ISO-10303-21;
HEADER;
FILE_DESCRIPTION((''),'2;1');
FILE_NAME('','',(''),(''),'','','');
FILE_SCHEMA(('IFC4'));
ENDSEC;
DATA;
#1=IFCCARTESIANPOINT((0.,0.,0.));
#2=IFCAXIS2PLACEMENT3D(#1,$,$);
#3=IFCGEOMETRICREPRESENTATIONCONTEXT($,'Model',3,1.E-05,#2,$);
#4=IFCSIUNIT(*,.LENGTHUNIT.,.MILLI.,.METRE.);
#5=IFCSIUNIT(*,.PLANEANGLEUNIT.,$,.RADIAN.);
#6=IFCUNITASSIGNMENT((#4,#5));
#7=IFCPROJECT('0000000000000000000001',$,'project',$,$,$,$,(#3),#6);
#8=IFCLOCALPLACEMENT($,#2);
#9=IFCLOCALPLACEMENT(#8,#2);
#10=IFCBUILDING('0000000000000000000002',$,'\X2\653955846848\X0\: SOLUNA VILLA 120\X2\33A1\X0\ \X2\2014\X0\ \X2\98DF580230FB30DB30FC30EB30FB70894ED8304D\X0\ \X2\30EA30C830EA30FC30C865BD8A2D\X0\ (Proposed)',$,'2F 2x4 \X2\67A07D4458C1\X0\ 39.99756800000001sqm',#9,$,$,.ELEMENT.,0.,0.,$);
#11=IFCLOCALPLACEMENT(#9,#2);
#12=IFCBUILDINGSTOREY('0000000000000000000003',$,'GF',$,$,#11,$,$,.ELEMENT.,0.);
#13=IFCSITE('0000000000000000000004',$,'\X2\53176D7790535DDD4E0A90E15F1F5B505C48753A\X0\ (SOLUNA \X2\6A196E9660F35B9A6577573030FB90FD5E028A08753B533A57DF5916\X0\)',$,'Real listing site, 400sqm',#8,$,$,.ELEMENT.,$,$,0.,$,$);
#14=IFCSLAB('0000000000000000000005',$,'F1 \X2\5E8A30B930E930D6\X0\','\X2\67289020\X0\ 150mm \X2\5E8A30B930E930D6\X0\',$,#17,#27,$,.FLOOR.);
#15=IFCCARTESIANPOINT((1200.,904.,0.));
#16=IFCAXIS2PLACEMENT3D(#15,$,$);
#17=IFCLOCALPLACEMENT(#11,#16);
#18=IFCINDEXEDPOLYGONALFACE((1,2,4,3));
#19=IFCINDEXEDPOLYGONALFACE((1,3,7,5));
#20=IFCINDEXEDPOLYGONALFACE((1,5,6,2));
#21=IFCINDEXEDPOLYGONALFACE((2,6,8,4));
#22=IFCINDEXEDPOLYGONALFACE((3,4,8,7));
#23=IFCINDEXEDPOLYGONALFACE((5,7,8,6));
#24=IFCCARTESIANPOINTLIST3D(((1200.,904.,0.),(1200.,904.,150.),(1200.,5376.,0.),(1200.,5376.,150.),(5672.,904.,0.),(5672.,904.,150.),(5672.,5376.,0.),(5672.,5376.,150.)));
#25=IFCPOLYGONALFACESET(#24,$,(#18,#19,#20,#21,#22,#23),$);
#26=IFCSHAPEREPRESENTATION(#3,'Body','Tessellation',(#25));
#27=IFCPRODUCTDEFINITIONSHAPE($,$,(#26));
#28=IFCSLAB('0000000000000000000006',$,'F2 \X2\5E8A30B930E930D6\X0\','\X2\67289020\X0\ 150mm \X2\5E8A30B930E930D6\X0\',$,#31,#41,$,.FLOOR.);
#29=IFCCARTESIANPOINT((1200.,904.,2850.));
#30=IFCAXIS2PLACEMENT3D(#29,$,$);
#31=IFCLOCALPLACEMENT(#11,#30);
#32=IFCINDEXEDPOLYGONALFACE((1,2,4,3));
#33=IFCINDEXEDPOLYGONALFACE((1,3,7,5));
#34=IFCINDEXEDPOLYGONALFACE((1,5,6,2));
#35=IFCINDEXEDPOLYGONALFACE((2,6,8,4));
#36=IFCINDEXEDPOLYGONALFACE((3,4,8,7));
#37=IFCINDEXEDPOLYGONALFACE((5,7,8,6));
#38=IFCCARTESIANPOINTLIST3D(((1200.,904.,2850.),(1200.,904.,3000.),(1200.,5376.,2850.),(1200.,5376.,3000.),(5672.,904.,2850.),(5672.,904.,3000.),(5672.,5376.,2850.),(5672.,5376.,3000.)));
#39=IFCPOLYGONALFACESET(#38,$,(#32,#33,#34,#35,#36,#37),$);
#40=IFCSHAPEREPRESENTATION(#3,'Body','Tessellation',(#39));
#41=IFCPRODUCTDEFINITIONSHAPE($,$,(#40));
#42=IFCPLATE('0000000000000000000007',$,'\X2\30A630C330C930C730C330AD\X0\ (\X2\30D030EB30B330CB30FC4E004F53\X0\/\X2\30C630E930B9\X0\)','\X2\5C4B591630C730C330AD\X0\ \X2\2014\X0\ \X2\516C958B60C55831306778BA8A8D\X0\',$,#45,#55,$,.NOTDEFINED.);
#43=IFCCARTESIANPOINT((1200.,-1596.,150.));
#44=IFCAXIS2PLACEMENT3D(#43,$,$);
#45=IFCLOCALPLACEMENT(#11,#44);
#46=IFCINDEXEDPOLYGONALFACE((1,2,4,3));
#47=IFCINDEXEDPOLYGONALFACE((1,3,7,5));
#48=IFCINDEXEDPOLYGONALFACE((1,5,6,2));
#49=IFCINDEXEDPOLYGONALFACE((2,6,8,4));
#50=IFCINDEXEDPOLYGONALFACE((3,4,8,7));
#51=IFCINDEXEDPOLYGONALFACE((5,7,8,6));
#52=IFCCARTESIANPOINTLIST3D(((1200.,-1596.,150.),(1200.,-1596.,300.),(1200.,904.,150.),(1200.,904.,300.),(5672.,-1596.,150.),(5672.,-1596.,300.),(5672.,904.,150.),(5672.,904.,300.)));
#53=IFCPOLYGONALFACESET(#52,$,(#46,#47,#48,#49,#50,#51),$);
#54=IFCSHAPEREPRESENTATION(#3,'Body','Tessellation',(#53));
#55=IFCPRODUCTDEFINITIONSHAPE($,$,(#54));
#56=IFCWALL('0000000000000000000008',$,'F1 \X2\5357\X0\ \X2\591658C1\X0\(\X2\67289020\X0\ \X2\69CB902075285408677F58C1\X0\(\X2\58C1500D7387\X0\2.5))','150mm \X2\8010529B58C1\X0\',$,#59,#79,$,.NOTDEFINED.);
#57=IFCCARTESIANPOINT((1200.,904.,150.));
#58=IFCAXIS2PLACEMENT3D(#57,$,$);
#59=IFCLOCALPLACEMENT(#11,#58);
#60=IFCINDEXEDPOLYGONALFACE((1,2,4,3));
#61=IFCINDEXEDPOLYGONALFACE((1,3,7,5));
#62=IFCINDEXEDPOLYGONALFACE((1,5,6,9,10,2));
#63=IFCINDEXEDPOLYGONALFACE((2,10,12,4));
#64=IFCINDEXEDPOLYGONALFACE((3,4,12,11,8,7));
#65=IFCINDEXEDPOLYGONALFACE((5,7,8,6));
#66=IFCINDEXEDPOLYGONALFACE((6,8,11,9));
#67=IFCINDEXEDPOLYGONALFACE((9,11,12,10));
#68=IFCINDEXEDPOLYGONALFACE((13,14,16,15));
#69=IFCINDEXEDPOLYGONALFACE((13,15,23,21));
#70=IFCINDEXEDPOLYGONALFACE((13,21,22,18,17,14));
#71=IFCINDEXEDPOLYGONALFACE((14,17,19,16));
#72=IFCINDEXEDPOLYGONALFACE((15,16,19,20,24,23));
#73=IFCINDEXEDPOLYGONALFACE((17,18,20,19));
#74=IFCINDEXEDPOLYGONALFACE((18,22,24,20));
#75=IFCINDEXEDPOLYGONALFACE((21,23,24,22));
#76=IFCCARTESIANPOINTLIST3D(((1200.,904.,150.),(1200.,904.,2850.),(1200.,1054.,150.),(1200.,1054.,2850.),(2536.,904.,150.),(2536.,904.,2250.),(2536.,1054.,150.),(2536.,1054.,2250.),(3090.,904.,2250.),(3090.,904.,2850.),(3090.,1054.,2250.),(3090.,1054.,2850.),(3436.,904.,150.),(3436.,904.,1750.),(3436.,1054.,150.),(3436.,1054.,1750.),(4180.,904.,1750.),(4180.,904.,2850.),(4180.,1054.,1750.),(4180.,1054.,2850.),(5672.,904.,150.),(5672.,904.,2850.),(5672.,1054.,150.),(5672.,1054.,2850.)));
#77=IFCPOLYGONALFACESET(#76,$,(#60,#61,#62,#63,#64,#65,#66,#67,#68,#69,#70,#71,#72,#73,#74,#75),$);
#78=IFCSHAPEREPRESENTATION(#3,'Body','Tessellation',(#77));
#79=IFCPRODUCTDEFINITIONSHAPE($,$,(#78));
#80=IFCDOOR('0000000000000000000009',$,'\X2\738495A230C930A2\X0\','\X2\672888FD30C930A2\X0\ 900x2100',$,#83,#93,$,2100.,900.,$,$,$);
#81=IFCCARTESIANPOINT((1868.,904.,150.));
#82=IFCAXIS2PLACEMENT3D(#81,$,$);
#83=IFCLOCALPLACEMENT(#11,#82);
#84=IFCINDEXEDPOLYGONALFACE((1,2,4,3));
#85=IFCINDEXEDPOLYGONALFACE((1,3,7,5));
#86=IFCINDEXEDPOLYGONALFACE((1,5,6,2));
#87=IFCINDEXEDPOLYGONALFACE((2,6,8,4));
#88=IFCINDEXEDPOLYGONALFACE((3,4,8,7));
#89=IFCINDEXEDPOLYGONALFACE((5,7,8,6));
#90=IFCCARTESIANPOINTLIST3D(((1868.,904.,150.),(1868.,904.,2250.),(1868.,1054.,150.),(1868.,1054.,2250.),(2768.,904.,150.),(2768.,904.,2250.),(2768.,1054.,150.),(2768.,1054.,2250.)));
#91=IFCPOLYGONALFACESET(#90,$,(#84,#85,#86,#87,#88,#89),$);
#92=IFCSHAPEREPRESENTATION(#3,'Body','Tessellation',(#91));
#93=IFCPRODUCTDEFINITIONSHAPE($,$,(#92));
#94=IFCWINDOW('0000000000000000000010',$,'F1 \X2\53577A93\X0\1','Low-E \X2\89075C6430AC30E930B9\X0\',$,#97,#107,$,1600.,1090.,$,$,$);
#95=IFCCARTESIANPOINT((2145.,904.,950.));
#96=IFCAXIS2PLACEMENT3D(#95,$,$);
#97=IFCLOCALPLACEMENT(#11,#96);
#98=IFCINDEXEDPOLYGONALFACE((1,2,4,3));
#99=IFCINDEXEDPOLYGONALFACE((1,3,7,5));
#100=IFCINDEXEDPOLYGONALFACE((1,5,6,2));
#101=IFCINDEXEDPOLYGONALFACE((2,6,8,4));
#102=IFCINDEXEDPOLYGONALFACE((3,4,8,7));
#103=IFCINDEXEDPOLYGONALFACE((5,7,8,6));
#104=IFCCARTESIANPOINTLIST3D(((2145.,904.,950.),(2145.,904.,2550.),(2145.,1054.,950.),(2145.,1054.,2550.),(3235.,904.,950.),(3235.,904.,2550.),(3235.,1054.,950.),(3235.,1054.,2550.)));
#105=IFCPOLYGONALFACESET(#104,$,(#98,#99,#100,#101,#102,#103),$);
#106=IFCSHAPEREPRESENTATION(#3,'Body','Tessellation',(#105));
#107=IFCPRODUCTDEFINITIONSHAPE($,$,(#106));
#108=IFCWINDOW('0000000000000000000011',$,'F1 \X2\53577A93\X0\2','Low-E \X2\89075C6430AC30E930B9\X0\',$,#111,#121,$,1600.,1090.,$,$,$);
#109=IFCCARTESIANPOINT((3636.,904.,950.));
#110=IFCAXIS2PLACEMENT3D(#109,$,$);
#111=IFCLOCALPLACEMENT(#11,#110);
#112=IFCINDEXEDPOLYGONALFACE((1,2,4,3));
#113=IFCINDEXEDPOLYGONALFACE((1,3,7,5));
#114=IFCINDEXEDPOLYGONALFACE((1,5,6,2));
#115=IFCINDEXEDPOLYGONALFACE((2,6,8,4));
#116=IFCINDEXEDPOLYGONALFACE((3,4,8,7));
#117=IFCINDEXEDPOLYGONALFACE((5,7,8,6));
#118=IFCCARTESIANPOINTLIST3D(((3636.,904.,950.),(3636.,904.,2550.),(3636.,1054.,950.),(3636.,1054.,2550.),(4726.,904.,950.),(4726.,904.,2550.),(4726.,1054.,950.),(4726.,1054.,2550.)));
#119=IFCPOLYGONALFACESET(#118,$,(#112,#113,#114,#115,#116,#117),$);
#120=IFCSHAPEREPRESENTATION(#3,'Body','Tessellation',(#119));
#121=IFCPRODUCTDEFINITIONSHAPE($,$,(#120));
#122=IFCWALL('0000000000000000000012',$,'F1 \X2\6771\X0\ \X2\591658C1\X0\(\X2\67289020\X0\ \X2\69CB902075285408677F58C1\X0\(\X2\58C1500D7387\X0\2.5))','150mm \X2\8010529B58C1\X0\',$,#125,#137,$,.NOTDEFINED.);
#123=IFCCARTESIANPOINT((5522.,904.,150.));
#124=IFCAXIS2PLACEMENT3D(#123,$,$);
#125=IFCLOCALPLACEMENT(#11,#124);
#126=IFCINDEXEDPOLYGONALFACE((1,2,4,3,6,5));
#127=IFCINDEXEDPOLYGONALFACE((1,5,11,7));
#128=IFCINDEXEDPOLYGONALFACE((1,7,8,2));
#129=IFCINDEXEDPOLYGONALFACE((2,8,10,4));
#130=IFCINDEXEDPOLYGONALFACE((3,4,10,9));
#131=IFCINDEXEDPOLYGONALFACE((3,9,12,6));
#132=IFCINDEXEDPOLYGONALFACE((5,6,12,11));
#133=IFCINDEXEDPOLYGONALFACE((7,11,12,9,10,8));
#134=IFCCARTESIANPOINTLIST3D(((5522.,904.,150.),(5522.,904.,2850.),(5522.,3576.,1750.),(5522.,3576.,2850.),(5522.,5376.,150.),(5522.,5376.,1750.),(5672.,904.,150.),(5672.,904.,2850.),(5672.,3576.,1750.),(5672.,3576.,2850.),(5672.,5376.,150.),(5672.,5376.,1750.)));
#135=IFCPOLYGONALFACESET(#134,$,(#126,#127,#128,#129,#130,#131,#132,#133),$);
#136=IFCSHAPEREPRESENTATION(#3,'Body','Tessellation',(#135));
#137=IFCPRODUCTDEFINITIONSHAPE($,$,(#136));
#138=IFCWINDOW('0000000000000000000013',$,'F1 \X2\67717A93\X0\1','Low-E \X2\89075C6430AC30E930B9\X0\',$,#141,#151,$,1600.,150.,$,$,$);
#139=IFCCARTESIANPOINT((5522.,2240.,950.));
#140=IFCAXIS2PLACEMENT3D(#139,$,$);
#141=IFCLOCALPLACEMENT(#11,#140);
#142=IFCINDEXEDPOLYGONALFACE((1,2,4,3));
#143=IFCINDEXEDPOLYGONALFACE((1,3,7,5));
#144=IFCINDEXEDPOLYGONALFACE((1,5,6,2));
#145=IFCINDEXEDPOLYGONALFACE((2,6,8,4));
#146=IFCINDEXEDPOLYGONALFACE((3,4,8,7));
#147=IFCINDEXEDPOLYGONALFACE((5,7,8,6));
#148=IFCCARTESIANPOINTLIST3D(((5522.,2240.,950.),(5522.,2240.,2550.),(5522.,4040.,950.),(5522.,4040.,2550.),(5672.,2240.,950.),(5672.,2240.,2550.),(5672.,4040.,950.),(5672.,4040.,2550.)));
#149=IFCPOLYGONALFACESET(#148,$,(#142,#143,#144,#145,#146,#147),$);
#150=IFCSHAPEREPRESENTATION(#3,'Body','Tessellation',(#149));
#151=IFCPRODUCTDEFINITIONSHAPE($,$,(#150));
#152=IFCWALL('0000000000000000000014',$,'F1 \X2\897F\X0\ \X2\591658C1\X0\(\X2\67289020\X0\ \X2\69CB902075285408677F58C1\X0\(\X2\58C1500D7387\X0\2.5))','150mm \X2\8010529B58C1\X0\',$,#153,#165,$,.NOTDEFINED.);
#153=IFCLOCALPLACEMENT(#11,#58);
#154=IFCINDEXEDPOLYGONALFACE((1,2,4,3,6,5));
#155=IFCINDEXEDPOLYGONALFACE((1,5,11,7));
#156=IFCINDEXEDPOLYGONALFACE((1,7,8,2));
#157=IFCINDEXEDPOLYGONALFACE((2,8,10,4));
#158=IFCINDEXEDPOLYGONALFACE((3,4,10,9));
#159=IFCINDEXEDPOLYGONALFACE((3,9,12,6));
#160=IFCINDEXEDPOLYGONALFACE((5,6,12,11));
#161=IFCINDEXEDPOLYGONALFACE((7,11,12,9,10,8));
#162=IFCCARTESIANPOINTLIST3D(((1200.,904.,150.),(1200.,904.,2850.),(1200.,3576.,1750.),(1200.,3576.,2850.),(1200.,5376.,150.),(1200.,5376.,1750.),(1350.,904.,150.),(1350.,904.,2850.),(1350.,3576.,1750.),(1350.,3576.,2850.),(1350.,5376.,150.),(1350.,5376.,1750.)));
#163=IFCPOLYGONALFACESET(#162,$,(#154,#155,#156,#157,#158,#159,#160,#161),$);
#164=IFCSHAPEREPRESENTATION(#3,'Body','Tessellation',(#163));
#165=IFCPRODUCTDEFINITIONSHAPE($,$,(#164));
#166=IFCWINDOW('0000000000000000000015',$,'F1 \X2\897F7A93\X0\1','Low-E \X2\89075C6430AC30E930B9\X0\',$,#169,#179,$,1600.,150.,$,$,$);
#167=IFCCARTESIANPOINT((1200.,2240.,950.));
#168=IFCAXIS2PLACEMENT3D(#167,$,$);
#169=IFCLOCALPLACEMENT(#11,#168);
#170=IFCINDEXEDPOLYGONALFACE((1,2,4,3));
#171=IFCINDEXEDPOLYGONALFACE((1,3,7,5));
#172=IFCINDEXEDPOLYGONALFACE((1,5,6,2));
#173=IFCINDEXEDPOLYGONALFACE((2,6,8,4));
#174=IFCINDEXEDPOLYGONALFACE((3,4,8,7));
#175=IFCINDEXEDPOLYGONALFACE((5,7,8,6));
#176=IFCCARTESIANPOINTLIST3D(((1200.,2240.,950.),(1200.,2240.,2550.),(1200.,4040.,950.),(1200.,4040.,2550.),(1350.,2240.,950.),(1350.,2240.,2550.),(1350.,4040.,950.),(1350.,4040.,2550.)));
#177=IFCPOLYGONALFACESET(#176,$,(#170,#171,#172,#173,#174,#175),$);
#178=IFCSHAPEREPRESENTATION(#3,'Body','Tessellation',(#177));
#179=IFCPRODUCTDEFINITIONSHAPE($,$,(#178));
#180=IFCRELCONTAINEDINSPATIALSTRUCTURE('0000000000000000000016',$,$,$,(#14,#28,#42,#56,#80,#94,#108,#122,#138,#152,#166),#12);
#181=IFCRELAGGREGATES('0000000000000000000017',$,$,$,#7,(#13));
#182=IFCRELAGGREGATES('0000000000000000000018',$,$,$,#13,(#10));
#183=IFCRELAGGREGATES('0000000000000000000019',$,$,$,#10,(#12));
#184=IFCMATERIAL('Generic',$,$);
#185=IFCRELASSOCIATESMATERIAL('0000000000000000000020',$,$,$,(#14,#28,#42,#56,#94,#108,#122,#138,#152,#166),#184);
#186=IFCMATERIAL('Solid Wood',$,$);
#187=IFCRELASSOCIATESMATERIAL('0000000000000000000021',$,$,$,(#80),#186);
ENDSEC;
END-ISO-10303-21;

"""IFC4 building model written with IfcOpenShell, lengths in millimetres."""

from ifc_helpers import new_model, si_unit, frame, frame_2d, origin, place, context, project, spatial, rectangle, extrude, material, element, fill, save


model = new_model("IFC4")

# Units and contexts
model_context = context("Model", 3, precision=1e-05, world=origin())
ifc_project = project(units=[si_unit("LENGTHUNIT", "METRE", prefix="MILLI"), si_unit("PLANEANGLEUNIT", "RADIAN")], contexts=[model_context])

# Site, building, storey
site_placement = place(None, origin())
site = spatial("IfcSite", under=ifc_project, at=site_placement, Name="北海道川上郡弟子屈町 (SOLUNA 標準想定敷地・都市計画区域外)", ObjectType="Real listing site, 400sqm", CompositionType="ELEMENT", RefElevation=0.0)
building_placement = place(site_placement, origin())
building = spatial("IfcBuilding", under=site, at=building_placement, Name="改善案: SOLUNA VILLA 120㎡ — 食堂・ホール・炉付き リトリート施設 (Proposed)", ObjectType="2F 2x4 枠組壁 39.99756800000001sqm", CompositionType="ELEMENT", ElevationOfRefHeight=0.0, ElevationOfTerrain=0.0)
storey_placement = place(building_placement, origin())
storey = spatial("IfcBuildingStorey", under=building, at=storey_placement, Name="GF", CompositionType="ELEMENT", Elevation=0.0)

# Slabs
ifc_material_1 = material(Name="Generic")
slab_1_placement = place(storey_placement, frame((1200.0, 904.0, 0.0)))
element("IfcSlab", 1, at=slab_1_placement, inside=storey, material=ifc_material_1, Name="F1 床スラブ", Description="木造 150mm 床スラブ", PredefinedType="FLOOR", context=model_context, shape_type="SweptSolid", body=[
    extrude(rectangle(XDim=4472.0, YDim=4472.0, at=frame_2d((2236.0, 2236.0))), frame((1200.0, 904.0, 0.0)), (0.0, 0.0, 1.0), 150.0),
])
slab_2_placement = place(storey_placement, frame((1200.0, 904.0, 2850.0)))
element("IfcSlab", 2, at=slab_2_placement, inside=storey, material=ifc_material_1, Name="F2 床スラブ", Description="木造 150mm 床スラブ", PredefinedType="FLOOR", context=model_context, shape_type="SweptSolid", body=[
    extrude(rectangle(XDim=4472.0, YDim=4472.0, at=frame_2d((2236.0, 2236.0))), frame((1200.0, 904.0, 2850.0)), (0.0, 0.0, 1.0), 150.0),
])

# Plate
plate_placement = place(storey_placement, frame((1200.0, -1596.0, 150.0)))
element("IfcPlate", 3, at=plate_placement, inside=storey, material=ifc_material_1, Name="ウッドデッキ (バルコニー一体/テラス)", Description="屋外デッキ — 公開情報で確認", PredefinedType="NOTDEFINED", context=model_context, shape_type="SweptSolid", body=[
    extrude(rectangle(XDim=4472.0, YDim=2500.0, at=frame_2d((2236.0, 1250.0))), frame((1200.0, -1596.0, 150.0)), (0.0, 0.0, 1.0), 150.0),
])

# Wall, openings, door, windows
wall_1_placement = place(storey_placement, frame((1200.0, 904.0, 150.0)))
wall_1 = element("IfcWall", 4, at=wall_1_placement, inside=storey, material=ifc_material_1, Name="F1 南 外壁(木造 構造用合板壁(壁倍率2.5))", Description="150mm 耐力壁", PredefinedType="NOTDEFINED", context=model_context, shape_type="SweptSolid", body=[
    extrude(rectangle(XDim=4472.0, YDim=150.0, at=frame_2d((2236.0, 75.0))), frame((1200.0, 904.0, 150.0)), (0.0, 0.0, 1.0), 2700.0),
])
opening_1_placement = place(storey_placement, frame((1868.0, 904.0, 150.0)))
opening_1 = element("IfcOpeningElement", 5, at=opening_1_placement, cuts=wall_1, PredefinedType="NOTDEFINED", context=model_context, shape_type="SweptSolid", body=[
    extrude(rectangle(XDim=900.0, YDim=150.0, at=frame_2d((450.0, 75.0))), frame((1868.0, 904.0, 150.0)), (0.0, 0.0, 1.0), 2100.0),
])
opening_2_placement = place(storey_placement, frame((2145.0, 904.0, 950.0)))
opening_2 = element("IfcOpeningElement", 6, at=opening_2_placement, cuts=wall_1, PredefinedType="NOTDEFINED", context=model_context, shape_type="SweptSolid", body=[
    extrude(rectangle(XDim=1090.0, YDim=150.0, at=frame_2d((545.0, 75.0))), frame((2145.0, 904.0, 950.0)), (0.0, 0.0, 1.0), 1600.0),
])
opening_3_placement = place(storey_placement, frame((3636.0, 904.0, 950.0)))
opening_3 = element("IfcOpeningElement", 7, at=opening_3_placement, cuts=wall_1, PredefinedType="NOTDEFINED", context=model_context, shape_type="SweptSolid", body=[
    extrude(rectangle(XDim=1090.0, YDim=150.0, at=frame_2d((545.0, 75.0))), frame((3636.0, 904.0, 950.0)), (0.0, 0.0, 1.0), 1600.0),
])
ifc_material_2 = material(Name="Solid Wood")
door_placement = place(storey_placement, frame((1868.0, 904.0, 150.0)))
door = element("IfcDoor", 8, at=door_placement, inside=storey, material=ifc_material_2, Name="玄関ドア", Description="木製ドア 900x2100", OverallHeight=2100.0, OverallWidth=900.0, context=model_context, shape_type="SweptSolid", body=[
    extrude(rectangle(XDim=900.0, YDim=150.0, at=frame_2d((450.0, 75.0))), frame((1868.0, 904.0, 150.0)), (0.0, 0.0, 1.0), 2100.0),
])
fill(opening_1, door)
window_1_placement = place(storey_placement, frame((2145.0, 904.0, 950.0)))
window_1 = element("IfcWindow", 9, at=window_1_placement, inside=storey, material=ifc_material_1, Name="F1 南窓1", Description="Low-E 複層ガラス", OverallHeight=1600.0, OverallWidth=1090.0, context=model_context, shape_type="SweptSolid", body=[
    extrude(rectangle(XDim=1090.0, YDim=150.0, at=frame_2d((545.0, 75.0))), frame((2145.0, 904.0, 950.0)), (0.0, 0.0, 1.0), 1600.0),
])
fill(opening_2, window_1)
window_2_placement = place(storey_placement, frame((3636.0, 904.0, 950.0)))
window_2 = element("IfcWindow", 10, at=window_2_placement, inside=storey, material=ifc_material_1, Name="F1 南窓2", Description="Low-E 複層ガラス", OverallHeight=1600.0, OverallWidth=1090.0, context=model_context, shape_type="SweptSolid", body=[
    extrude(rectangle(XDim=1090.0, YDim=150.0, at=frame_2d((545.0, 75.0))), frame((3636.0, 904.0, 950.0)), (0.0, 0.0, 1.0), 1600.0),
])
fill(opening_3, window_2)

# Walls, openings, windows
wall_2_placement = place(storey_placement, frame((5522.0, 904.0, 150.0)))
wall_2 = element("IfcWall", 11, at=wall_2_placement, inside=storey, material=ifc_material_1, Name="F1 東 外壁(木造 構造用合板壁(壁倍率2.5))", Description="150mm 耐力壁", PredefinedType="NOTDEFINED", context=model_context, shape_type="SweptSolid", body=[
    extrude(rectangle(XDim=150.0, YDim=4472.0, at=frame_2d((75.0, 2236.0))), frame((5522.0, 904.0, 150.0)), (0.0, 0.0, 1.0), 2700.0),
])
opening_4_placement = place(storey_placement, frame((5522.0, 2240.0, 950.0)))
opening_4 = element("IfcOpeningElement", 12, at=opening_4_placement, cuts=wall_2, PredefinedType="NOTDEFINED", context=model_context, shape_type="SweptSolid", body=[
    extrude(rectangle(XDim=150.0, YDim=1800.0, at=frame_2d((75.0, 900.0))), frame((5522.0, 2240.0, 950.0)), (0.0, 0.0, 1.0), 1600.0),
])
window_3_placement = place(storey_placement, frame((5522.0, 2240.0, 950.0)))
window_3 = element("IfcWindow", 13, at=window_3_placement, inside=storey, material=ifc_material_1, Name="F1 東窓1", Description="Low-E 複層ガラス", OverallHeight=1600.0, OverallWidth=150.0, context=model_context, shape_type="SweptSolid", body=[
    extrude(rectangle(XDim=150.0, YDim=1800.0, at=frame_2d((75.0, 900.0))), frame((5522.0, 2240.0, 950.0)), (0.0, 0.0, 1.0), 1600.0),
])
fill(opening_4, window_3)
wall_3_placement = place(storey_placement, frame((1200.0, 904.0, 150.0)))
wall_3 = element("IfcWall", 14, at=wall_3_placement, inside=storey, material=ifc_material_1, Name="F1 西 外壁(木造 構造用合板壁(壁倍率2.5))", Description="150mm 耐力壁", PredefinedType="NOTDEFINED", context=model_context, shape_type="SweptSolid", body=[
    extrude(rectangle(XDim=150.0, YDim=4472.0, at=frame_2d((75.0, 2236.0))), frame((1200.0, 904.0, 150.0)), (0.0, 0.0, 1.0), 2700.0),
])
opening_5_placement = place(storey_placement, frame((1200.0, 2240.0, 950.0)))
opening_5 = element("IfcOpeningElement", 15, at=opening_5_placement, cuts=wall_3, PredefinedType="NOTDEFINED", context=model_context, shape_type="SweptSolid", body=[
    extrude(rectangle(XDim=150.0, YDim=1800.0, at=frame_2d((75.0, 900.0))), frame((1200.0, 2240.0, 950.0)), (0.0, 0.0, 1.0), 1600.0),
])
window_4_placement = place(storey_placement, frame((1200.0, 2240.0, 950.0)))
window_4 = element("IfcWindow", 16, at=window_4_placement, inside=storey, material=ifc_material_1, Name="F1 西窓1", Description="Low-E 複層ガラス", OverallHeight=1600.0, OverallWidth=150.0, context=model_context, shape_type="SweptSolid", body=[
    extrude(rectangle(XDim=150.0, YDim=1800.0, at=frame_2d((75.0, 900.0))), frame((1200.0, 2240.0, 950.0)), (0.0, 0.0, 1.0), 1600.0),
])
fill(opening_5, window_4)

save(model, "model.ifc")
